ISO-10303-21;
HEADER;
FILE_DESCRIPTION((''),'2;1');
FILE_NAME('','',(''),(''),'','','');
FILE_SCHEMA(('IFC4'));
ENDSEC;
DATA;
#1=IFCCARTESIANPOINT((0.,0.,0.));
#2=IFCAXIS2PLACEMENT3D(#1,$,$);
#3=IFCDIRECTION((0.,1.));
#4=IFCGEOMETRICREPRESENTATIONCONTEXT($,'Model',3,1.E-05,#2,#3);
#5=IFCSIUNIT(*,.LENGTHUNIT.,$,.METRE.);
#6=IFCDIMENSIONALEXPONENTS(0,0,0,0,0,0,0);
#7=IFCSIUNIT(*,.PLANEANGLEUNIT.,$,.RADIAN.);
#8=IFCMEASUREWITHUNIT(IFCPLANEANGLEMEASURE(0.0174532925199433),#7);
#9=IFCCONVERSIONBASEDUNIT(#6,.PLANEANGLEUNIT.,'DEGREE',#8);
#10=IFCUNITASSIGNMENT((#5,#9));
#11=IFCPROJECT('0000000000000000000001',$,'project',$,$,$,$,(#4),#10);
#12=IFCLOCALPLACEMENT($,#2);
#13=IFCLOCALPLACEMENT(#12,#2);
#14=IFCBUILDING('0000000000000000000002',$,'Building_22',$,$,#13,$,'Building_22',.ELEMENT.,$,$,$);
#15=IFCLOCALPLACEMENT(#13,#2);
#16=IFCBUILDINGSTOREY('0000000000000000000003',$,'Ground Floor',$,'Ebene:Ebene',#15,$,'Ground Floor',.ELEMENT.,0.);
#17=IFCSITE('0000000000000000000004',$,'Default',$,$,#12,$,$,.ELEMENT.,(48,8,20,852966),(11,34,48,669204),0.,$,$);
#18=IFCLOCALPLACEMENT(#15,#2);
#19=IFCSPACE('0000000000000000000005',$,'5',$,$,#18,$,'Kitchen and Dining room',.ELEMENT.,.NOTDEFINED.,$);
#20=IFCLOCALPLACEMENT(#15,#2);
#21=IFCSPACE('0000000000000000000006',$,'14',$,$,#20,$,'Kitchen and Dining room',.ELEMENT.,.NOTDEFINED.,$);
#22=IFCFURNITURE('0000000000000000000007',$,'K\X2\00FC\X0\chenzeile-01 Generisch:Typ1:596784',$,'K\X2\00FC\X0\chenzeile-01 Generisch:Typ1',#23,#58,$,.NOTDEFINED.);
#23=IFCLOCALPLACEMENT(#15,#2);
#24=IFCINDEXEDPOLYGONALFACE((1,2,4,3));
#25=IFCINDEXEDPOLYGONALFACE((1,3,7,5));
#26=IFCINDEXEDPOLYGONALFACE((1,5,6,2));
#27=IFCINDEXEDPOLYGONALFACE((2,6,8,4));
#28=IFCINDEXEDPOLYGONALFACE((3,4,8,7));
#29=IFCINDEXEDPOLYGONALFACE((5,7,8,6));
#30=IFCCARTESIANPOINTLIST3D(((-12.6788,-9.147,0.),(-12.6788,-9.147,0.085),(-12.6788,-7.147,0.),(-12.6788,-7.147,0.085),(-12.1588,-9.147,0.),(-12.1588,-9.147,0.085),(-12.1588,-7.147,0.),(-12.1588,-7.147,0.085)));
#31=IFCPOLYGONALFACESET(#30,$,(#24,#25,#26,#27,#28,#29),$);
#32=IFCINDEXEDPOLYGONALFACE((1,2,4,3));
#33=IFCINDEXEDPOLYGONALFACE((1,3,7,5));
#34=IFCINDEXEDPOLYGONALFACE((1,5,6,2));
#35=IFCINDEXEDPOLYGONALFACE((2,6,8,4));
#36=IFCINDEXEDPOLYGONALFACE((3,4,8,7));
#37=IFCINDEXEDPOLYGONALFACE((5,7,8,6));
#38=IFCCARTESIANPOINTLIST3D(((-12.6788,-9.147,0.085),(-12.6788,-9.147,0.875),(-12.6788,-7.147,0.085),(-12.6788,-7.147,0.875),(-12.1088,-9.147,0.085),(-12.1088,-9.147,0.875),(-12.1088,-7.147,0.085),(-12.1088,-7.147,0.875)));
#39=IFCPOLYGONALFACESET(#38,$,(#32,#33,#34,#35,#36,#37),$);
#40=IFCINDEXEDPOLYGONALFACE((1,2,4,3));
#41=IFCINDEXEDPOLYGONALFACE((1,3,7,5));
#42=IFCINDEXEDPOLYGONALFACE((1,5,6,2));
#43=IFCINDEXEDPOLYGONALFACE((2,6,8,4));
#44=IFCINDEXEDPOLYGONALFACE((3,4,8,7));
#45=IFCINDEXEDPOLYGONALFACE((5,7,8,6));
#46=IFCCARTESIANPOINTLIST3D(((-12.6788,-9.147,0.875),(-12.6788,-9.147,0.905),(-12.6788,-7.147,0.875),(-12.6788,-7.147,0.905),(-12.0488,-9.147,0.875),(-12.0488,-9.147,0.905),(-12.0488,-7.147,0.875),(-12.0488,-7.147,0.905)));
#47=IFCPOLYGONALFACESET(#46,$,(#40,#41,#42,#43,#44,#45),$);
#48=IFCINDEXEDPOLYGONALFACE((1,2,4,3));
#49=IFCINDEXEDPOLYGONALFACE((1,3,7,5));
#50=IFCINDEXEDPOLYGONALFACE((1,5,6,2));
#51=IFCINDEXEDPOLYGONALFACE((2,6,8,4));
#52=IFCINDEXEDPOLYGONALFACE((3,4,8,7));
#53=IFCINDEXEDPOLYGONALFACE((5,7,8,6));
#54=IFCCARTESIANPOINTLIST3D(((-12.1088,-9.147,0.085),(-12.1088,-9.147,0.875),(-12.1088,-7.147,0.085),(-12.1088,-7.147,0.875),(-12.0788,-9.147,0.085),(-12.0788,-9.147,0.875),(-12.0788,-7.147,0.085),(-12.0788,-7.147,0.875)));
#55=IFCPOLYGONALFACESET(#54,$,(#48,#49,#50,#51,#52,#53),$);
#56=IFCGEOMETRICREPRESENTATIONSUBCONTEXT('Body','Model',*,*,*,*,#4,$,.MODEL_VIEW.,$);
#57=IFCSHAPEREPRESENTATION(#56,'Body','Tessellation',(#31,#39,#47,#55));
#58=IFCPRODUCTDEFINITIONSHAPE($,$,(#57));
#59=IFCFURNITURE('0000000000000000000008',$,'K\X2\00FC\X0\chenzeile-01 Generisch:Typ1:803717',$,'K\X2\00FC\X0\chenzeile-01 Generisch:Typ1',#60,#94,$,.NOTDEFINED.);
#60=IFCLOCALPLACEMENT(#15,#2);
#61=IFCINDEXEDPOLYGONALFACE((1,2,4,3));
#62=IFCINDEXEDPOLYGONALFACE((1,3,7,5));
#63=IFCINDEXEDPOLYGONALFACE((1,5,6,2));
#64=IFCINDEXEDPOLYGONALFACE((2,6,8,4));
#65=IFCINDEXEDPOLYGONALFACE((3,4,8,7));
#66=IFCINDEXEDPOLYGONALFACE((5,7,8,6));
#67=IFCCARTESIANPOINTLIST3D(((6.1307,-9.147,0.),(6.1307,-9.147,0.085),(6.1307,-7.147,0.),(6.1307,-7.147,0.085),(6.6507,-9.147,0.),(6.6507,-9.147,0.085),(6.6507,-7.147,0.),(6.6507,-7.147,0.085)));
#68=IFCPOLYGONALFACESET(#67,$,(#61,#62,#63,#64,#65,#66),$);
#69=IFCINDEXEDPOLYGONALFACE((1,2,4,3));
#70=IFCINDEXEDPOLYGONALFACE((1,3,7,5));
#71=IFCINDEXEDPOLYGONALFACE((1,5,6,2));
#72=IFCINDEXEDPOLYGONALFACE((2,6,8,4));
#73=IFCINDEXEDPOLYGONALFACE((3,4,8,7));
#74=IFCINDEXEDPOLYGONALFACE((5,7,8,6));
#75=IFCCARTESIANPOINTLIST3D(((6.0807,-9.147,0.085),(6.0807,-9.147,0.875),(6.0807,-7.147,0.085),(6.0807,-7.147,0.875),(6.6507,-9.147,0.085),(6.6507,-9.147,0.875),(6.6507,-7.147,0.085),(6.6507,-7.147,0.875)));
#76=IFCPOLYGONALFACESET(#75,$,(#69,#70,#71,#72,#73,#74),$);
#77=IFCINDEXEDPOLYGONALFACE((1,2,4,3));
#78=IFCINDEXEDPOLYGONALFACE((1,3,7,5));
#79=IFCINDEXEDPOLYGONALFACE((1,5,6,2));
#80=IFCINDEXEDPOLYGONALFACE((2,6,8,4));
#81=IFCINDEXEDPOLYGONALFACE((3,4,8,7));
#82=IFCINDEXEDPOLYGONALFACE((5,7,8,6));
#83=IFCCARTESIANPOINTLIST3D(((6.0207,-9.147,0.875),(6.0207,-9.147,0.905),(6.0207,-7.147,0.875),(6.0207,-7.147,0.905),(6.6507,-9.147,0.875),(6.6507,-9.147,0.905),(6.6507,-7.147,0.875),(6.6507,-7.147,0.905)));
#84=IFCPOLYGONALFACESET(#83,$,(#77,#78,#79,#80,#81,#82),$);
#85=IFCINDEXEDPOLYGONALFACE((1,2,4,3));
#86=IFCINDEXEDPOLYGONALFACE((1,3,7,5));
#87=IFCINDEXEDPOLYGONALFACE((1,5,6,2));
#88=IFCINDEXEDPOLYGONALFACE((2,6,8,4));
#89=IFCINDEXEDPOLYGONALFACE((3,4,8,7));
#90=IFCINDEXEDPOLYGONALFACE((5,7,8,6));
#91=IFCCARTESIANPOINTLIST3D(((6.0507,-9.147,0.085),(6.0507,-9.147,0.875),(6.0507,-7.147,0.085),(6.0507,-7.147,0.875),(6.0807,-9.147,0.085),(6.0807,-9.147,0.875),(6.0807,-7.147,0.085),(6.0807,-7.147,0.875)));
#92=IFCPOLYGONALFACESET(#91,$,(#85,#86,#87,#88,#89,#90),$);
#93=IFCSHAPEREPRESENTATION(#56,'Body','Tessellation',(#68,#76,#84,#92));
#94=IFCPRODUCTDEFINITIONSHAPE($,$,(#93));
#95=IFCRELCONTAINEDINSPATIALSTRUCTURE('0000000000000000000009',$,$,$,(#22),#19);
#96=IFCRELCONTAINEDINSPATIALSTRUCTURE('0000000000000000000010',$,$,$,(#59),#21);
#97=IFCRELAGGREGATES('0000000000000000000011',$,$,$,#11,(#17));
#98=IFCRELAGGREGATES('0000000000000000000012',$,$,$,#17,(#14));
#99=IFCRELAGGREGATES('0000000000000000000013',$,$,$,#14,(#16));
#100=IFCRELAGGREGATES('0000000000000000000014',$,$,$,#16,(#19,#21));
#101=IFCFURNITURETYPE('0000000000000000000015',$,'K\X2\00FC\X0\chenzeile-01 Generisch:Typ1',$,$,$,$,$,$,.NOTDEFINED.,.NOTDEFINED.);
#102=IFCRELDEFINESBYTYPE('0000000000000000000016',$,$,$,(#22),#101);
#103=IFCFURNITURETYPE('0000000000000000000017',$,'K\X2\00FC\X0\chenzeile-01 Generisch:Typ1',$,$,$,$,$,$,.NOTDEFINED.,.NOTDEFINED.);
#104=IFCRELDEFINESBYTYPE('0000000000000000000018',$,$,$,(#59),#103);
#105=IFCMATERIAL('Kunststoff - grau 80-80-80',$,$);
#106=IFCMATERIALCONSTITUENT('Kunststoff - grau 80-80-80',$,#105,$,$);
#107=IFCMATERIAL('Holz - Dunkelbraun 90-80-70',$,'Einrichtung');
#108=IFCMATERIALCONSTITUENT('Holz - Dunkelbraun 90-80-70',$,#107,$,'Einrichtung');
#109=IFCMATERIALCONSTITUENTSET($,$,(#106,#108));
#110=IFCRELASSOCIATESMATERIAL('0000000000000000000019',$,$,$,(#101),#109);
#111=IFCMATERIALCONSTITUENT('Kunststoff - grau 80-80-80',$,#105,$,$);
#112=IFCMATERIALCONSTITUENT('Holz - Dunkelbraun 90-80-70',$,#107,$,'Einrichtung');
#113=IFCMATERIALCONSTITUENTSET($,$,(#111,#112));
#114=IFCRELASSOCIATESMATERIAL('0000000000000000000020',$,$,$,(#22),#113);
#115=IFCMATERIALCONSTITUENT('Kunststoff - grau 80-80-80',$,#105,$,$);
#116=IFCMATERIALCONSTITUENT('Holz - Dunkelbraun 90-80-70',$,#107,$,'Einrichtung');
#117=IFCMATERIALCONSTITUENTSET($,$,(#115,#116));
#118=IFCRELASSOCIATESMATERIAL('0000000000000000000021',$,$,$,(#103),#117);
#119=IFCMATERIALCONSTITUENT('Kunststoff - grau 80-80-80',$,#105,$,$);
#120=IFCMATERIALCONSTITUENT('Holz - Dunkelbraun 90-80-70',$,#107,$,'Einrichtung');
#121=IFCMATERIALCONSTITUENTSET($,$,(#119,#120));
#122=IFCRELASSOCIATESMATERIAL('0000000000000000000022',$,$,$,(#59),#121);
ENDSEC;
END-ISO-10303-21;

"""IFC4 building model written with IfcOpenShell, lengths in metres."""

from ifc_helpers import new_model, entity, si_unit, converted_unit, direction, frame, origin, place, context, subcontext, project, spatial, indexed_curve, outline, extrude, source, transform, mapped, material, constituent, constituent_set, type_object, type_shapes, element, save


model = new_model("IFC4")

# Units and contexts
model_context = context("Model", 3, precision=1e-05, world=origin(), true_north=direction((0.0, 1.0)))
body_context = subcontext(model_context, "Body", "Model", "MODEL_VIEW")
ifc_project = project(units=[si_unit("LENGTHUNIT", "METRE"), converted_unit("PLANEANGLEUNIT", "DEGREE", entity("IfcPlaneAngleMeasure", 0.0174532925199433), si_unit("PLANEANGLEUNIT", "RADIAN"), dimensions=[0, 0, 0, 0, 0, 0, 0])], contexts=[model_context])

# Site, building, storey
site_placement = place(None, origin())
site = spatial("IfcSite", under=ifc_project, at=site_placement, Name="Default", CompositionType="ELEMENT", RefLatitude=(48, 8, 20, 852966), RefLongitude=(11, 34, 48, 669204), RefElevation=0.0)
building_placement = place(site_placement, origin())
building = spatial("IfcBuilding", under=site, at=building_placement, Name="Building_22", LongName="Building_22", CompositionType="ELEMENT")
storey_placement = place(building_placement, origin())
storey = spatial("IfcBuildingStorey", under=building, at=storey_placement, Name="Ground Floor", ObjectType="Ebene:Ebene", LongName="Ground Floor", CompositionType="ELEMENT", Elevation=0.0)

# Shared definitions
space_1_placement = place(storey_placement, origin())
space_1 = spatial("IfcSpace", under=storey, at=space_1_placement, Name="5", LongName="Kitchen and Dining room", CompositionType="ELEMENT", PredefinedType="NOTDEFINED")

# Furniture
ifc_material_1 = material(Name="Kunststoff - grau 80-80-80")
ifc_constituent_1 = constituent(ifc_material_1, Name="Kunststoff - grau 80-80-80")
ifc_material_2 = material(Name="Holz - Dunkelbraun 90-80-70", Category="Einrichtung")
ifc_constituent_2 = constituent(ifc_material_2, Name="Holz - Dunkelbraun 90-80-70", Category="Einrichtung")
ifc_constituent_set_1 = constituent_set(constituents=[ifc_constituent_1, ifc_constituent_2])
ifc_constituent_3 = constituent(ifc_material_1, Name="Kunststoff - grau 80-80-80")
ifc_constituent_4 = constituent(ifc_material_2, Name="Holz - Dunkelbraun 90-80-70", Category="Einrichtung")
ifc_constituent_set_2 = constituent_set(constituents=[ifc_constituent_3, ifc_constituent_4])
furniture_type_1 = type_object("IfcFurnitureType", Name="Küchenzeile-01 Generisch:Typ1", AssemblyPlace="NOTDEFINED", PredefinedType="NOTDEFINED", material=ifc_constituent_set_2)
shared_shape_1 = source(origin(), body_context, "Body", "SweptSolid", [
    extrude(outline(indexed_curve([(-1.0, -0.26), (1.0, -0.26), (1.0, 0.26), (-1.0, 0.26), (-1.0, -0.26)], self_intersect=False)), frame((-0.72, 0.04, 0.0)), (0.0, 0.0, 1.0), 0.085),
    extrude(outline(indexed_curve([(-1.0, -0.285), (1.0, -0.285), (1.0, 0.285), (-1.0, 0.285), (-1.0, -0.285)], self_intersect=False)), frame((-0.72, 0.015, 0.085)), (0.0, 0.0, 1.0), 0.79),
    extrude(outline(indexed_curve([(-1.0, -0.315), (1.0, -0.315), (1.0, 0.315), (-1.0, 0.315), (-1.0, -0.315)], self_intersect=False)), frame((-0.72, -0.015, 0.875)), (0.0, 0.0, 1.0), 0.03),
    extrude(outline(indexed_curve([(-1.0, -0.015), (1.0, -0.015), (1.0, 0.015), (-1.0, 0.015), (-1.0, -0.015)], self_intersect=False)), frame((-0.72, -0.285, 0.085)), (0.0, 0.0, 1.0), 0.79),
])
type_shapes(furniture_type_1, [shared_shape_1])
furniture_1_placement = place(space_1_placement, frame((-12.3788, -7.427, 0.0), z_axis=(0.0, 0.0, 1.0), x_axis=(0.0, 1.0, 0.0)))
element("IfcFurniture", 1, at=furniture_1_placement, inside=space_1, type_object=furniture_type_1, material=ifc_constituent_set_1, Name="Küchenzeile-01 Generisch:Typ1:596784", ObjectType="Küchenzeile-01 Generisch:Typ1", PredefinedType="NOTDEFINED", context=body_context, shape_type="MappedRepresentation", body=[
    mapped(shared_shape_1, transform((0.0, 0.0, 0.0), scale=1.0)),
])

# Shared definitions
space_2_placement = place(storey_placement, origin())
space_2 = spatial("IfcSpace", under=storey, at=space_2_placement, Name="14", LongName="Kitchen and Dining room", CompositionType="ELEMENT", PredefinedType="NOTDEFINED")

# Furniture
ifc_constituent_5 = constituent(ifc_material_1, Name="Kunststoff - grau 80-80-80")
ifc_constituent_6 = constituent(ifc_material_2, Name="Holz - Dunkelbraun 90-80-70", Category="Einrichtung")
ifc_constituent_set_3 = constituent_set(constituents=[ifc_constituent_5, ifc_constituent_6])
ifc_constituent_7 = constituent(ifc_material_1, Name="Kunststoff - grau 80-80-80")
ifc_constituent_8 = constituent(ifc_material_2, Name="Holz - Dunkelbraun 90-80-70", Category="Einrichtung")
ifc_constituent_set_4 = constituent_set(constituents=[ifc_constituent_7, ifc_constituent_8])
furniture_type_2 = type_object("IfcFurnitureType", Name="Küchenzeile-01 Generisch:Typ1", AssemblyPlace="NOTDEFINED", PredefinedType="NOTDEFINED", material=ifc_constituent_set_4)
shared_shape_2 = source(origin(), body_context, "Body", "SweptSolid", [
    extrude(outline(indexed_curve([(-0.26, -1.0), (0.26, -1.0), (0.26, 1.0), (-0.26, 1.0), (-0.26, -1.0)], self_intersect=False)), frame((-0.72, -0.04, 0.0), z_axis=(0.0, 0.0, 1.0), x_axis=(0.0, -1.0, 0.0)), (0.0, 0.0, 1.0), 0.085),
    extrude(outline(indexed_curve([(-0.285, -1.0), (0.285, -1.0), (0.285, 1.0), (-0.285, 1.0), (-0.285, -1.0)], self_intersect=False)), frame((-0.72, -0.015, 0.085), z_axis=(0.0, 0.0, 1.0), x_axis=(0.0, -1.0, 0.0)), (0.0, 0.0, 1.0), 0.79),
    extrude(outline(indexed_curve([(-0.315, -1.0), (0.315, -1.0), (0.315, 1.0), (-0.315, 1.0), (-0.315, -1.0)], self_intersect=False)), frame((-0.72, 0.015, 0.875), z_axis=(0.0, 0.0, 1.0), x_axis=(0.0, -1.0, 0.0)), (0.0, 0.0, 1.0), 0.03),
    extrude(outline(indexed_curve([(-0.015, -1.0), (0.015, -1.0), (0.015, 1.0), (-0.015, 1.0), (-0.015, -1.0)], self_intersect=False)), frame((-0.72, 0.285, 0.085), z_axis=(0.0, 0.0, 1.0), x_axis=(0.0, -1.0, 0.0)), (0.0, 0.0, 1.0), 0.79),
])
type_shapes(furniture_type_2, [shared_shape_2])
furniture_2_placement = place(space_2_placement, frame((6.3507, -7.427, 0.0), z_axis=(0.0, 0.0, 1.0), x_axis=(0.0, 1.0, 0.0)))
element("IfcFurniture", 2, at=furniture_2_placement, inside=space_2, type_object=furniture_type_2, material=ifc_constituent_set_3, Name="Küchenzeile-01 Generisch:Typ1:803717", ObjectType="Küchenzeile-01 Generisch:Typ1", PredefinedType="NOTDEFINED", context=body_context, shape_type="MappedRepresentation", body=[
    mapped(shared_shape_2, transform((0.0, 0.0, 0.0), scale=1.0)),
])

save(model, "model.ifc")
